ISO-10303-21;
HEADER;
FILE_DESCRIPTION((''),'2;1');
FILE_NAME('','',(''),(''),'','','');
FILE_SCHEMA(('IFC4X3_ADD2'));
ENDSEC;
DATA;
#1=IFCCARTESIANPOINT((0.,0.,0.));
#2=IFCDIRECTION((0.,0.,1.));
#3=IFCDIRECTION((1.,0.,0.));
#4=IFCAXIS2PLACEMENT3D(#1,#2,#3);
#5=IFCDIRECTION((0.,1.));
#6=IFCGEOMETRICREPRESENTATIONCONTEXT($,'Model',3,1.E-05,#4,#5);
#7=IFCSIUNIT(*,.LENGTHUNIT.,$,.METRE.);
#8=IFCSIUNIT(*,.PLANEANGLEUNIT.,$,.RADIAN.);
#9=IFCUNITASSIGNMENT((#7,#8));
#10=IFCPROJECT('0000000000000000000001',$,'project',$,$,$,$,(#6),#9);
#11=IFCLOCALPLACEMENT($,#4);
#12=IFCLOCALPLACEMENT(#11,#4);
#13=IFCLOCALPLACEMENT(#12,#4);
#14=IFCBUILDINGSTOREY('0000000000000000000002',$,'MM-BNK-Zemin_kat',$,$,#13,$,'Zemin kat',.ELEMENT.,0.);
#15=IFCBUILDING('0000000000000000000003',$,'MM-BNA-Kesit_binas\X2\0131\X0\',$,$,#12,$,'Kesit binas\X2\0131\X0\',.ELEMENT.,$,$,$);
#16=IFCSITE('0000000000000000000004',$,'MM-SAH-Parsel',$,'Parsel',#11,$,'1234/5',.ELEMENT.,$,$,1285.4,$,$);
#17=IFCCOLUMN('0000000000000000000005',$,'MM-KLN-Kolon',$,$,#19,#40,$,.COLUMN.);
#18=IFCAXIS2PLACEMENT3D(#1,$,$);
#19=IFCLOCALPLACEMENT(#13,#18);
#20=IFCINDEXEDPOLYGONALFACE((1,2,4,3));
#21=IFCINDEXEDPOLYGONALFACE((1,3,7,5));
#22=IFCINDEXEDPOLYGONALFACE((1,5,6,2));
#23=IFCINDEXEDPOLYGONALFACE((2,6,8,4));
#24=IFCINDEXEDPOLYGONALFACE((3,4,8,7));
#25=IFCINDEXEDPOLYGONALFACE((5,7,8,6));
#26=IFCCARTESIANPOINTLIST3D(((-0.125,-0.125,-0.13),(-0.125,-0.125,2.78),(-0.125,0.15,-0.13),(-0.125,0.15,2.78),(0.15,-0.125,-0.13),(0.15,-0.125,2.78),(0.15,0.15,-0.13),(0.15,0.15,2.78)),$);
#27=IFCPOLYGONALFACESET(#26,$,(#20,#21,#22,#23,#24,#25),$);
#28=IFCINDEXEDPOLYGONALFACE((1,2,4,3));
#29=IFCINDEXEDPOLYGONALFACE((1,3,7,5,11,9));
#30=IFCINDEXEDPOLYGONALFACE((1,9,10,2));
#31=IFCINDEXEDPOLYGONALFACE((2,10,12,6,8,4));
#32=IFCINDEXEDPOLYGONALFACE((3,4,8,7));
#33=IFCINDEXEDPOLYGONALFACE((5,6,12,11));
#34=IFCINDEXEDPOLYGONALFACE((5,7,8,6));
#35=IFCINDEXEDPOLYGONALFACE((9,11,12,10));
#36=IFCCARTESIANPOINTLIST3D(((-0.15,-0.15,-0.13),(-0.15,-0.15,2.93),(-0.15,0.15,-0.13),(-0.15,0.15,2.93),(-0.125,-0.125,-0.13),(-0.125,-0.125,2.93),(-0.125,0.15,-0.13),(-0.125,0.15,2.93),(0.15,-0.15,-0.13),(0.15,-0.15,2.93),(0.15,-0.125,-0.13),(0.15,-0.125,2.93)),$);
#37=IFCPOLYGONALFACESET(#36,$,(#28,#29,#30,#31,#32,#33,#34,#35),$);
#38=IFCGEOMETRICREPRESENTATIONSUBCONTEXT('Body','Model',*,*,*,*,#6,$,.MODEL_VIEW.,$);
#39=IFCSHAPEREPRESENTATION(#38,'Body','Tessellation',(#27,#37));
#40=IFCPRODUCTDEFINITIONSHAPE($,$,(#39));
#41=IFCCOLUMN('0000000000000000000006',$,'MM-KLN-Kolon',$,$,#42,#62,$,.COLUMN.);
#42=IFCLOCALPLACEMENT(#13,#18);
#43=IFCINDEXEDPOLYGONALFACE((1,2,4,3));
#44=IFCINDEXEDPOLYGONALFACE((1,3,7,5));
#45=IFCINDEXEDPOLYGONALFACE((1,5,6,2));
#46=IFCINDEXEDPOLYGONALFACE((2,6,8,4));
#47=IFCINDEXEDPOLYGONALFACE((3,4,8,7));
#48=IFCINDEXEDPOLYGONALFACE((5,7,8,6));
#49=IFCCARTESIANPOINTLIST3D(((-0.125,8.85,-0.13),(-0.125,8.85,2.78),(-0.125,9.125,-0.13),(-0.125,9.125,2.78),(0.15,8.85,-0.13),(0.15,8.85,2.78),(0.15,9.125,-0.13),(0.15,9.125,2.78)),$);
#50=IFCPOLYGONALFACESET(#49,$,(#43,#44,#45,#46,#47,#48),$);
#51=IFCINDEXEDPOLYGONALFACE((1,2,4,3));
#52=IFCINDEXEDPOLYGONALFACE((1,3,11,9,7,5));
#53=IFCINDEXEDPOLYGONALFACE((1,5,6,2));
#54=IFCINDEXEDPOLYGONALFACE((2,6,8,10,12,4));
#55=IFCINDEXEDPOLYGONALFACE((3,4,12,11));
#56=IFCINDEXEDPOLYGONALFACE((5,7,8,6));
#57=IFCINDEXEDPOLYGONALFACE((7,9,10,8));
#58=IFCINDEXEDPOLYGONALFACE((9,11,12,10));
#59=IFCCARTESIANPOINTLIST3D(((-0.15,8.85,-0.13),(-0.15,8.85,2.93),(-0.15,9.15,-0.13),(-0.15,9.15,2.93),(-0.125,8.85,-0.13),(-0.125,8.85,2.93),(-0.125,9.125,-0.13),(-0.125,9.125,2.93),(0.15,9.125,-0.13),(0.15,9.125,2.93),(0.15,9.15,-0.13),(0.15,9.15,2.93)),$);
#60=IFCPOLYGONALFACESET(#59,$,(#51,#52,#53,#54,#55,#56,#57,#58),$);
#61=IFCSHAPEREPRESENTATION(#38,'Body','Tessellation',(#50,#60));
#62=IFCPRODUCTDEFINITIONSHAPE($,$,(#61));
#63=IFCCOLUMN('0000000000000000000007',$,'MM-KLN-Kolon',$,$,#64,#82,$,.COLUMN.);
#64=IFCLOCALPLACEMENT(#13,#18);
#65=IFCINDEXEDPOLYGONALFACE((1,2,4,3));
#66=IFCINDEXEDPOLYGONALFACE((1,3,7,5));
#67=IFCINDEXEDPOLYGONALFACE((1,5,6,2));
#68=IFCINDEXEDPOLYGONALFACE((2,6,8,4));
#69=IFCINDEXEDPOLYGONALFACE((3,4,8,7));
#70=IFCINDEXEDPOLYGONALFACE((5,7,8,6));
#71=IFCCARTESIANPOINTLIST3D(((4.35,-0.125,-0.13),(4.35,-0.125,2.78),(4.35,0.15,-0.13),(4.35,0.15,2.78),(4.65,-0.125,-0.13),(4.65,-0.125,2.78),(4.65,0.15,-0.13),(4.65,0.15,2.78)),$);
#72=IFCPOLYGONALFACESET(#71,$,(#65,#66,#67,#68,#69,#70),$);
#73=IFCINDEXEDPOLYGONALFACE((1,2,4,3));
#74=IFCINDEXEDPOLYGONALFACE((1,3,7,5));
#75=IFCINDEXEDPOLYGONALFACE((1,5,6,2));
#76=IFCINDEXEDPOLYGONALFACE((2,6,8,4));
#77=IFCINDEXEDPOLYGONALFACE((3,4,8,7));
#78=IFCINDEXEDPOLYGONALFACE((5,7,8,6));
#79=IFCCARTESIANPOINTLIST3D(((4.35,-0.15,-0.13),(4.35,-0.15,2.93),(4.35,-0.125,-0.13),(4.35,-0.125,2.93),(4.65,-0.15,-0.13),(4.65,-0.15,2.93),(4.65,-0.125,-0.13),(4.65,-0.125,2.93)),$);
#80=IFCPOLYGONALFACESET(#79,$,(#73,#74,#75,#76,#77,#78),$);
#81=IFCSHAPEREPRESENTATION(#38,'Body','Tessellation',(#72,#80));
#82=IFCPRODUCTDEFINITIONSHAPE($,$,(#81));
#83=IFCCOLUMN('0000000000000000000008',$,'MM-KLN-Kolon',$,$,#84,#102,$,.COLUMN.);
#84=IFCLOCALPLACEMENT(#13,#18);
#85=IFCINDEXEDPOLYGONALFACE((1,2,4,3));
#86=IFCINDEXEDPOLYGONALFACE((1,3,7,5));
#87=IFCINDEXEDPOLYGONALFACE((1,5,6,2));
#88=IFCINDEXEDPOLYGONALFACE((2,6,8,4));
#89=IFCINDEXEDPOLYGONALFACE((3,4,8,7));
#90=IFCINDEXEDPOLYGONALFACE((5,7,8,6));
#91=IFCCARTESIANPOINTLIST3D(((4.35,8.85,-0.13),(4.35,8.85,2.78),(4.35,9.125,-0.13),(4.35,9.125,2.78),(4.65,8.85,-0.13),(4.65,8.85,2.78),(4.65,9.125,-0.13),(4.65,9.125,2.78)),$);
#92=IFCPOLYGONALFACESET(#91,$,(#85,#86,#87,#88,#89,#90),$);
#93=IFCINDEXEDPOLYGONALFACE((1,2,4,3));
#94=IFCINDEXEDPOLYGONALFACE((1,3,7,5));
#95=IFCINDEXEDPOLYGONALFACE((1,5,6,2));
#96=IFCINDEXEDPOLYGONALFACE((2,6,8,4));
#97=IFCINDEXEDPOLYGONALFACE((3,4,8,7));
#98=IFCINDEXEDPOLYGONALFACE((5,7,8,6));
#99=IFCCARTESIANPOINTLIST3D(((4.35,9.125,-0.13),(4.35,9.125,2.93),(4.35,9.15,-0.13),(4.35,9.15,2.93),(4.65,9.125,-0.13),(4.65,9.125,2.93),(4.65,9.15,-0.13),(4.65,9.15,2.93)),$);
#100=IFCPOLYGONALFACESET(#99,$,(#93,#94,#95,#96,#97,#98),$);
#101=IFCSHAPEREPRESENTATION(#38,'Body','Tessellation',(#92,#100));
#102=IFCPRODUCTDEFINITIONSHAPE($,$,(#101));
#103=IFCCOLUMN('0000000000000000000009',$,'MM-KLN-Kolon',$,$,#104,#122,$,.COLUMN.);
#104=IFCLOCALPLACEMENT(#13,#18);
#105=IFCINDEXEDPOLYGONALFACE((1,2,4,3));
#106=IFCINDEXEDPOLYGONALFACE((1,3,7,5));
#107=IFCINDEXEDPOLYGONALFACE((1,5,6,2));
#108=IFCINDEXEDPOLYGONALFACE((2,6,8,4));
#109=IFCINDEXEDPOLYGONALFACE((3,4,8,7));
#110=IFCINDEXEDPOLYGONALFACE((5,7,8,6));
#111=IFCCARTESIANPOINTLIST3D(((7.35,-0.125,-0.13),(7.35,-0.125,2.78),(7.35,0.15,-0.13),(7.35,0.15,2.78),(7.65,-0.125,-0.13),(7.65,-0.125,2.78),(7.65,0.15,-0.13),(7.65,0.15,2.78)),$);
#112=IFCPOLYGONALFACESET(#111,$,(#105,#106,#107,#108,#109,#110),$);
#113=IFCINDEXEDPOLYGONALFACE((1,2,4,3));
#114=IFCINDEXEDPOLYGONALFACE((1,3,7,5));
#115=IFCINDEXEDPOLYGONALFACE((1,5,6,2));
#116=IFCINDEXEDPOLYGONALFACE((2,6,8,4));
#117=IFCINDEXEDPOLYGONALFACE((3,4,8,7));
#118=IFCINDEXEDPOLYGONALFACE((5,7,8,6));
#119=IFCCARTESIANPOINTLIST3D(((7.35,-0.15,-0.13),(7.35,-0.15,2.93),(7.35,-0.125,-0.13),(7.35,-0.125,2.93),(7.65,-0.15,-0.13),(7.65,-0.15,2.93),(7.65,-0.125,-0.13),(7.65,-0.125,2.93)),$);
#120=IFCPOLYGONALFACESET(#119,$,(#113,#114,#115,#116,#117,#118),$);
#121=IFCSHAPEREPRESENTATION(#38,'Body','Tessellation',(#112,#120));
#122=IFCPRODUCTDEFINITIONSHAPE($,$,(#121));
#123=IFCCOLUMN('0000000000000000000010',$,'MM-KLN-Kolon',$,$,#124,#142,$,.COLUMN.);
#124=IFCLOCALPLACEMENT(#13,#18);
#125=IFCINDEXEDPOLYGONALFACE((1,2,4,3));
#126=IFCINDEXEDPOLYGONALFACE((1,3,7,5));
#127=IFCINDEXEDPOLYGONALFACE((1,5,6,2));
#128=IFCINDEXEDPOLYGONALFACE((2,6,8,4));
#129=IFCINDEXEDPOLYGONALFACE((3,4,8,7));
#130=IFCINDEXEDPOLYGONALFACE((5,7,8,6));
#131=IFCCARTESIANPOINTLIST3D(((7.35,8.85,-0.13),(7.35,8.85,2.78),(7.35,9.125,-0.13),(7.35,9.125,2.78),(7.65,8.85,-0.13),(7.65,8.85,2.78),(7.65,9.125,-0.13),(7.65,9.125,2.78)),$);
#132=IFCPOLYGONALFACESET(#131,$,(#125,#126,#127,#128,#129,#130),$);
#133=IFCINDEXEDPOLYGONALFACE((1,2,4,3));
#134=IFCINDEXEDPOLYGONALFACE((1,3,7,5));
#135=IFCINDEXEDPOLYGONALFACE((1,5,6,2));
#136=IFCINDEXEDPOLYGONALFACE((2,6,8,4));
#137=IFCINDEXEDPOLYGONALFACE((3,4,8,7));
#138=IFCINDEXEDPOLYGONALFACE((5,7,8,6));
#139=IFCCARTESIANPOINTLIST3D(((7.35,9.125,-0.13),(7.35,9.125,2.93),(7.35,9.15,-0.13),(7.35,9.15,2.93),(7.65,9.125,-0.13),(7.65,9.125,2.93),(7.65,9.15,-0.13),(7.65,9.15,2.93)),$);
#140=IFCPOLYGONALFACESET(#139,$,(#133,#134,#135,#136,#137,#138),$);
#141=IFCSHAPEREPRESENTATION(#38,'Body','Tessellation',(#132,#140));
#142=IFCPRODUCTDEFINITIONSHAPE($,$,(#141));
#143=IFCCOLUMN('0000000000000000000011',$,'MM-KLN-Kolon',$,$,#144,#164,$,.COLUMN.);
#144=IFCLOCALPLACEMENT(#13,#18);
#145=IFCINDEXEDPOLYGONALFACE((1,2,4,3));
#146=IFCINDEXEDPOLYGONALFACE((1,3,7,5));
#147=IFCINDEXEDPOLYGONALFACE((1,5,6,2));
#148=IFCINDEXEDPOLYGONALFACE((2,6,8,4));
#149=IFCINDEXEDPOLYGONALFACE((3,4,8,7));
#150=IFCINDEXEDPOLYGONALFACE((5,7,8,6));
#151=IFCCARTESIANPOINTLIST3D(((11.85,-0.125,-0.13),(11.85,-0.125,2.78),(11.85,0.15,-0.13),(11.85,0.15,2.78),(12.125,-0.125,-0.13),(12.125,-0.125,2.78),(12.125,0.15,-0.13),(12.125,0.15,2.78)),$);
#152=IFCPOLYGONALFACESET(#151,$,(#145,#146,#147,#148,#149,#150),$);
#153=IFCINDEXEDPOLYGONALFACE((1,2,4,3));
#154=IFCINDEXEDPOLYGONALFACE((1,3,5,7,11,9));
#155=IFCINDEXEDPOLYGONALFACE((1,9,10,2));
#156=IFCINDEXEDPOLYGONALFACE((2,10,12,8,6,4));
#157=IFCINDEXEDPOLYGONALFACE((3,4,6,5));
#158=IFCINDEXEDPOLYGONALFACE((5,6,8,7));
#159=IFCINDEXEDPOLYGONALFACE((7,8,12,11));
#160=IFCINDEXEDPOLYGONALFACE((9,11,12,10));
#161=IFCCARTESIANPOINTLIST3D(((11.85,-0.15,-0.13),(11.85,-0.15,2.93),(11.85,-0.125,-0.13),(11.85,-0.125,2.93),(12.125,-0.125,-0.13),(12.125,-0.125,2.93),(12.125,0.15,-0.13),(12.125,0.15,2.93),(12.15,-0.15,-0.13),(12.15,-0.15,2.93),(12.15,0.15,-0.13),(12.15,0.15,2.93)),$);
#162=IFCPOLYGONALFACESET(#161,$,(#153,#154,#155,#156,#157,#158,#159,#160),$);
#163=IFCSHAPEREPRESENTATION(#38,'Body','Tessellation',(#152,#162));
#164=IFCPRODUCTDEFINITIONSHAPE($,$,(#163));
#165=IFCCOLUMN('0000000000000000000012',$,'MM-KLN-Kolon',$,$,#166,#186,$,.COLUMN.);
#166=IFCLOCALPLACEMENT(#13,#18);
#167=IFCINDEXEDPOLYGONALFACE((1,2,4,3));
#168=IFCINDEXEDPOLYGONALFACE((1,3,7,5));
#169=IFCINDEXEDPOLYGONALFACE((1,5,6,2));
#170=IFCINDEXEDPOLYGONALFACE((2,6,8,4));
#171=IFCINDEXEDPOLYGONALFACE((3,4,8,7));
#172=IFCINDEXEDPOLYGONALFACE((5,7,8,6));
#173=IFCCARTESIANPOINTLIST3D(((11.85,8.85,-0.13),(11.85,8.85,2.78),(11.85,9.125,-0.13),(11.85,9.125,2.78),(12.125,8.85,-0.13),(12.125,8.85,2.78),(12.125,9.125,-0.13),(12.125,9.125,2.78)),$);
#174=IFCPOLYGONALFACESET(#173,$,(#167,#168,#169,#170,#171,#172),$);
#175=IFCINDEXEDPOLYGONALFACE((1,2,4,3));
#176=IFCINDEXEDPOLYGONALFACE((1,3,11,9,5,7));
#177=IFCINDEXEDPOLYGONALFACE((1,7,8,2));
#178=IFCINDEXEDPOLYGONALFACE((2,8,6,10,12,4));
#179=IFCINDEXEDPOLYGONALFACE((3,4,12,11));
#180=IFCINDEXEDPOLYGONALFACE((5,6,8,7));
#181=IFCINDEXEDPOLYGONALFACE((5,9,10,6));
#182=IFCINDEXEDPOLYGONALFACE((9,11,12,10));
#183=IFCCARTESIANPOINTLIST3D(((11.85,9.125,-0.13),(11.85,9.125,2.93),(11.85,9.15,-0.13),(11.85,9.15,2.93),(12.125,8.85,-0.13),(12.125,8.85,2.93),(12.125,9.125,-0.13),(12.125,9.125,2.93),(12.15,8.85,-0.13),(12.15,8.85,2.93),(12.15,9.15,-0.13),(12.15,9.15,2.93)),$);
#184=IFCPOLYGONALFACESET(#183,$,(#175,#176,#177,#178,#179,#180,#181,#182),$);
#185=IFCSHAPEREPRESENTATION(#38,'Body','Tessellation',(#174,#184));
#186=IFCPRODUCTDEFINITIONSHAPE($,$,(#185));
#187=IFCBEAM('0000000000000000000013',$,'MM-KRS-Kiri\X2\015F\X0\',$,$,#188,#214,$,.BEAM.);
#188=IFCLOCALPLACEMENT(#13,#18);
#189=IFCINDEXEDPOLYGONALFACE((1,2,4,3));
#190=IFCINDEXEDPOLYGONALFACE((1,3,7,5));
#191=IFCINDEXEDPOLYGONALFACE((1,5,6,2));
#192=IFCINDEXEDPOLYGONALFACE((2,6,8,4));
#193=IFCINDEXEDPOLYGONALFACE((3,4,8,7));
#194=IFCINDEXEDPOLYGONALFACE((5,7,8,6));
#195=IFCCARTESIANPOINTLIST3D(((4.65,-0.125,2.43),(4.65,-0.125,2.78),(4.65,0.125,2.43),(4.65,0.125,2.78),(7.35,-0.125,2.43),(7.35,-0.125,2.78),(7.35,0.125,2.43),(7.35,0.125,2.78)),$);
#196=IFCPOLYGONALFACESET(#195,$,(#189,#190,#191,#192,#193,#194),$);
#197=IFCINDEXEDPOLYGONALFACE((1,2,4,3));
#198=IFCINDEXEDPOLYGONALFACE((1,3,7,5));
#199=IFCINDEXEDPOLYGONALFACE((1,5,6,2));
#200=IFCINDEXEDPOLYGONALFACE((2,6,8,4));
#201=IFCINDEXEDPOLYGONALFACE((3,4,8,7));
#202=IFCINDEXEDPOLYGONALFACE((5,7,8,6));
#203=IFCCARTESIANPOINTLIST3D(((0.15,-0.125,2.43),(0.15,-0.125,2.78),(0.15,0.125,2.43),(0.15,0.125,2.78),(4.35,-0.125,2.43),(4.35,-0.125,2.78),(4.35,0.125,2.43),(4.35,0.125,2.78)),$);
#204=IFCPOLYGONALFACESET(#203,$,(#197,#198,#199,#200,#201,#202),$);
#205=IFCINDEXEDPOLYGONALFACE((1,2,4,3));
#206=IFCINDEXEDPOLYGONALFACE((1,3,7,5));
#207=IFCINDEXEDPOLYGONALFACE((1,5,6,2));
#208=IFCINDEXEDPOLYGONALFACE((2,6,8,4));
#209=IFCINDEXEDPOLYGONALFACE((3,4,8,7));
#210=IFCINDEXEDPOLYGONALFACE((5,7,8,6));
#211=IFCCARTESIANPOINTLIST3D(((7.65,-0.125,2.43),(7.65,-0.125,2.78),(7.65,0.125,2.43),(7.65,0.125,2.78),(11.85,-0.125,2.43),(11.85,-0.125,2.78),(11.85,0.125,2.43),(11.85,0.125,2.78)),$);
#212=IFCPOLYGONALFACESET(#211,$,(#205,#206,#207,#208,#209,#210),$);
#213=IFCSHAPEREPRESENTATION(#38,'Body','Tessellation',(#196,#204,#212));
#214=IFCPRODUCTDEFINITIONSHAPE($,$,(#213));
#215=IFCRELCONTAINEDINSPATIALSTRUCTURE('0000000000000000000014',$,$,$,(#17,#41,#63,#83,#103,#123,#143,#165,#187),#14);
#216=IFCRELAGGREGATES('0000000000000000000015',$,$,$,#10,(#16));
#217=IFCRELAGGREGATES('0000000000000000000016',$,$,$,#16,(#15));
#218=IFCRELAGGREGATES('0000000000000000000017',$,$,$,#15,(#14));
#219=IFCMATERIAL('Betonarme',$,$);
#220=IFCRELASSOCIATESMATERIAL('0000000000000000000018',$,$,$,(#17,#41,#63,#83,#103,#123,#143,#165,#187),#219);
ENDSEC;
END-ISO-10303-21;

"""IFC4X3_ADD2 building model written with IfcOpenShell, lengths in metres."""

from ifc_helpers import new_model, si_unit, direction, frame, origin_with_axes, place, context, subcontext, project, spatial, polyline, outline, extrude, material, element, save


model = new_model("IFC4X3_ADD2")

# Units and contexts
model_context = context("Model", 3, precision=1e-05, world=origin_with_axes(), true_north=direction((0.0, 1.0)))
body_context = subcontext(model_context, "Body", "Model", "MODEL_VIEW")
ifc_project = project(units=[si_unit("LENGTHUNIT", "METRE"), si_unit("PLANEANGLEUNIT", "RADIAN")], contexts=[model_context])

# Site, building, storey
site_placement = place(None, origin_with_axes())
site = spatial("IfcSite", under=ifc_project, at=site_placement, Name="MM-SAH-Parsel", ObjectType="Parsel", LongName="1234/5", CompositionType="ELEMENT", RefElevation=1285.4)
building_placement = place(site_placement, origin_with_axes())
building = spatial("IfcBuilding", under=site, at=building_placement, Name="MM-BNA-Kesit_binası", LongName="Kesit binası", CompositionType="ELEMENT")
storey_placement = place(building_placement, origin_with_axes())
storey = spatial("IfcBuildingStorey", under=building, at=storey_placement, Name="MM-BNK-Zemin_kat", LongName="Zemin kat", CompositionType="ELEMENT", Elevation=0.0)

# Columns
ifc_material_1 = material(Name="Betonarme")
column_1_placement = place(storey_placement, origin_with_axes())
element("IfcColumn", 1, at=column_1_placement, inside=storey, material=ifc_material_1, Name="MM-KLN-Kolon", PredefinedType="COLUMN", context=body_context, shape_type="SweptSolid", body=[
    extrude(outline(polyline([(0.15, -0.125), (0.15, 0.15), (-0.125, 0.15), (-0.125, -0.125), (0.15, -0.125)])), frame((0.0, 0.0, -0.13)), (0.0, 0.0, 1.0), 2.91),
    extrude(outline(polyline([(-0.15, -0.15), (0.15, -0.15), (0.15, -0.125), (-0.125, -0.125), (-0.125, 0.15), (-0.15, 0.15), (-0.15, -0.15)])), frame((0.0, 0.0, -0.13)), (0.0, 0.0, 1.0), 3.06),
])
column_2_placement = place(storey_placement, origin_with_axes())
element("IfcColumn", 2, at=column_2_placement, inside=storey, material=ifc_material_1, Name="MM-KLN-Kolon", PredefinedType="COLUMN", context=body_context, shape_type="SweptSolid", body=[
    extrude(outline(polyline([(-0.125, 8.85), (0.15, 8.85), (0.15, 9.125), (-0.125, 9.125), (-0.125, 8.85)])), frame((0.0, 0.0, -0.13)), (0.0, 0.0, 1.0), 2.91),
    extrude(outline(polyline([(-0.15, 8.85), (-0.125, 8.85), (-0.125, 9.125), (0.15, 9.125), (0.15, 9.15), (-0.15, 9.15), (-0.15, 8.85)])), frame((0.0, 0.0, -0.13)), (0.0, 0.0, 1.0), 3.06),
])
column_3_placement = place(storey_placement, origin_with_axes())
element("IfcColumn", 3, at=column_3_placement, inside=storey, material=ifc_material_1, Name="MM-KLN-Kolon", PredefinedType="COLUMN", context=body_context, shape_type="SweptSolid", body=[
    extrude(outline(polyline([(4.65, -0.125), (4.65, 0.15), (4.35, 0.15), (4.35, -0.125), (4.65, -0.125)])), frame((0.0, 0.0, -0.13)), (0.0, 0.0, 1.0), 2.91),
    extrude(outline(polyline([(4.35, -0.15), (4.65, -0.15), (4.65, -0.125), (4.35, -0.125), (4.35, -0.15)])), frame((0.0, 0.0, -0.13)), (0.0, 0.0, 1.0), 3.06),
])
column_4_placement = place(storey_placement, origin_with_axes())
element("IfcColumn", 4, at=column_4_placement, inside=storey, material=ifc_material_1, Name="MM-KLN-Kolon", PredefinedType="COLUMN", context=body_context, shape_type="SweptSolid", body=[
    extrude(outline(polyline([(4.35, 8.85), (4.65, 8.85), (4.65, 9.125), (4.35, 9.125), (4.35, 8.85)])), frame((0.0, 0.0, -0.13)), (0.0, 0.0, 1.0), 2.91),
    extrude(outline(polyline([(4.65, 9.125), (4.65, 9.15), (4.35, 9.15), (4.35, 9.125), (4.65, 9.125)])), frame((0.0, 0.0, -0.13)), (0.0, 0.0, 1.0), 3.06),
])
column_5_placement = place(storey_placement, origin_with_axes())
element("IfcColumn", 5, at=column_5_placement, inside=storey, material=ifc_material_1, Name="MM-KLN-Kolon", PredefinedType="COLUMN", context=body_context, shape_type="SweptSolid", body=[
    extrude(outline(polyline([(7.65, -0.125), (7.65, 0.15), (7.35, 0.15), (7.35, -0.125), (7.65, -0.125)])), frame((0.0, 0.0, -0.13)), (0.0, 0.0, 1.0), 2.91),
    extrude(outline(polyline([(7.35, -0.15), (7.65, -0.15), (7.65, -0.125), (7.35, -0.125), (7.35, -0.15)])), frame((0.0, 0.0, -0.13)), (0.0, 0.0, 1.0), 3.06),
])
column_6_placement = place(storey_placement, origin_with_axes())
element("IfcColumn", 6, at=column_6_placement, inside=storey, material=ifc_material_1, Name="MM-KLN-Kolon", PredefinedType="COLUMN", context=body_context, shape_type="SweptSolid", body=[
    extrude(outline(polyline([(7.35, 8.85), (7.65, 8.85), (7.65, 9.125), (7.35, 9.125), (7.35, 8.85)])), frame((0.0, 0.0, -0.13)), (0.0, 0.0, 1.0), 2.91),
    extrude(outline(polyline([(7.65, 9.125), (7.65, 9.15), (7.35, 9.15), (7.35, 9.125), (7.65, 9.125)])), frame((0.0, 0.0, -0.13)), (0.0, 0.0, 1.0), 3.06),
])
column_7_placement = place(storey_placement, origin_with_axes())
element("IfcColumn", 7, at=column_7_placement, inside=storey, material=ifc_material_1, Name="MM-KLN-Kolon", PredefinedType="COLUMN", context=body_context, shape_type="SweptSolid", body=[
    extrude(outline(polyline([(12.125, 0.15), (11.85, 0.15), (11.85, -0.125), (12.125, -0.125), (12.125, 0.15)])), frame((0.0, 0.0, -0.13)), (0.0, 0.0, 1.0), 2.91),
    extrude(outline(polyline([(11.85, -0.15), (12.15, -0.15), (12.15, 0.15), (12.125, 0.15), (12.125, -0.125), (11.85, -0.125), (11.85, -0.15)])), frame((0.0, 0.0, -0.13)), (0.0, 0.0, 1.0), 3.06),
])
column_8_placement = place(storey_placement, origin_with_axes())
element("IfcColumn", 8, at=column_8_placement, inside=storey, material=ifc_material_1, Name="MM-KLN-Kolon", PredefinedType="COLUMN", context=body_context, shape_type="SweptSolid", body=[
    extrude(outline(polyline([(11.85, 8.85), (12.125, 8.85), (12.125, 9.125), (11.85, 9.125), (11.85, 8.85)])), frame((0.0, 0.0, -0.13)), (0.0, 0.0, 1.0), 2.91),
    extrude(outline(polyline([(12.125, 8.85), (12.15, 8.85), (12.15, 9.15), (11.85, 9.15), (11.85, 9.125), (12.125, 9.125), (12.125, 8.85)])), frame((0.0, 0.0, -0.13)), (0.0, 0.0, 1.0), 3.06),
])

# Beam
beam_1_placement = place(storey_placement, origin_with_axes())
element("IfcBeam", 9, at=beam_1_placement, inside=storey, material=ifc_material_1, Name="MM-KRS-Kiriş", PredefinedType="BEAM", context=body_context, shape_type="SweptSolid", body=[
    extrude(outline(polyline([(4.65, -0.125), (7.35, -0.125), (7.35, 0.125), (4.65, 0.125), (4.65, -0.125)])), frame((0.0, 0.0, 2.43)), (0.0, 0.0, 1.0), 0.35),
    extrude(outline(polyline([(0.15, -0.125), (4.35, -0.125), (4.35, 0.125), (0.15, 0.125), (0.15, -0.125)])), frame((0.0, 0.0, 2.43)), (0.0, 0.0, 1.0), 0.35),
    extrude(outline(polyline([(7.65, -0.125), (11.85, -0.125), (11.85, 0.125), (7.65, 0.125), (7.65, -0.125)])), frame((0.0, 0.0, 2.43)), (0.0, 0.0, 1.0), 0.35),
])

save(model, "model.ifc")
